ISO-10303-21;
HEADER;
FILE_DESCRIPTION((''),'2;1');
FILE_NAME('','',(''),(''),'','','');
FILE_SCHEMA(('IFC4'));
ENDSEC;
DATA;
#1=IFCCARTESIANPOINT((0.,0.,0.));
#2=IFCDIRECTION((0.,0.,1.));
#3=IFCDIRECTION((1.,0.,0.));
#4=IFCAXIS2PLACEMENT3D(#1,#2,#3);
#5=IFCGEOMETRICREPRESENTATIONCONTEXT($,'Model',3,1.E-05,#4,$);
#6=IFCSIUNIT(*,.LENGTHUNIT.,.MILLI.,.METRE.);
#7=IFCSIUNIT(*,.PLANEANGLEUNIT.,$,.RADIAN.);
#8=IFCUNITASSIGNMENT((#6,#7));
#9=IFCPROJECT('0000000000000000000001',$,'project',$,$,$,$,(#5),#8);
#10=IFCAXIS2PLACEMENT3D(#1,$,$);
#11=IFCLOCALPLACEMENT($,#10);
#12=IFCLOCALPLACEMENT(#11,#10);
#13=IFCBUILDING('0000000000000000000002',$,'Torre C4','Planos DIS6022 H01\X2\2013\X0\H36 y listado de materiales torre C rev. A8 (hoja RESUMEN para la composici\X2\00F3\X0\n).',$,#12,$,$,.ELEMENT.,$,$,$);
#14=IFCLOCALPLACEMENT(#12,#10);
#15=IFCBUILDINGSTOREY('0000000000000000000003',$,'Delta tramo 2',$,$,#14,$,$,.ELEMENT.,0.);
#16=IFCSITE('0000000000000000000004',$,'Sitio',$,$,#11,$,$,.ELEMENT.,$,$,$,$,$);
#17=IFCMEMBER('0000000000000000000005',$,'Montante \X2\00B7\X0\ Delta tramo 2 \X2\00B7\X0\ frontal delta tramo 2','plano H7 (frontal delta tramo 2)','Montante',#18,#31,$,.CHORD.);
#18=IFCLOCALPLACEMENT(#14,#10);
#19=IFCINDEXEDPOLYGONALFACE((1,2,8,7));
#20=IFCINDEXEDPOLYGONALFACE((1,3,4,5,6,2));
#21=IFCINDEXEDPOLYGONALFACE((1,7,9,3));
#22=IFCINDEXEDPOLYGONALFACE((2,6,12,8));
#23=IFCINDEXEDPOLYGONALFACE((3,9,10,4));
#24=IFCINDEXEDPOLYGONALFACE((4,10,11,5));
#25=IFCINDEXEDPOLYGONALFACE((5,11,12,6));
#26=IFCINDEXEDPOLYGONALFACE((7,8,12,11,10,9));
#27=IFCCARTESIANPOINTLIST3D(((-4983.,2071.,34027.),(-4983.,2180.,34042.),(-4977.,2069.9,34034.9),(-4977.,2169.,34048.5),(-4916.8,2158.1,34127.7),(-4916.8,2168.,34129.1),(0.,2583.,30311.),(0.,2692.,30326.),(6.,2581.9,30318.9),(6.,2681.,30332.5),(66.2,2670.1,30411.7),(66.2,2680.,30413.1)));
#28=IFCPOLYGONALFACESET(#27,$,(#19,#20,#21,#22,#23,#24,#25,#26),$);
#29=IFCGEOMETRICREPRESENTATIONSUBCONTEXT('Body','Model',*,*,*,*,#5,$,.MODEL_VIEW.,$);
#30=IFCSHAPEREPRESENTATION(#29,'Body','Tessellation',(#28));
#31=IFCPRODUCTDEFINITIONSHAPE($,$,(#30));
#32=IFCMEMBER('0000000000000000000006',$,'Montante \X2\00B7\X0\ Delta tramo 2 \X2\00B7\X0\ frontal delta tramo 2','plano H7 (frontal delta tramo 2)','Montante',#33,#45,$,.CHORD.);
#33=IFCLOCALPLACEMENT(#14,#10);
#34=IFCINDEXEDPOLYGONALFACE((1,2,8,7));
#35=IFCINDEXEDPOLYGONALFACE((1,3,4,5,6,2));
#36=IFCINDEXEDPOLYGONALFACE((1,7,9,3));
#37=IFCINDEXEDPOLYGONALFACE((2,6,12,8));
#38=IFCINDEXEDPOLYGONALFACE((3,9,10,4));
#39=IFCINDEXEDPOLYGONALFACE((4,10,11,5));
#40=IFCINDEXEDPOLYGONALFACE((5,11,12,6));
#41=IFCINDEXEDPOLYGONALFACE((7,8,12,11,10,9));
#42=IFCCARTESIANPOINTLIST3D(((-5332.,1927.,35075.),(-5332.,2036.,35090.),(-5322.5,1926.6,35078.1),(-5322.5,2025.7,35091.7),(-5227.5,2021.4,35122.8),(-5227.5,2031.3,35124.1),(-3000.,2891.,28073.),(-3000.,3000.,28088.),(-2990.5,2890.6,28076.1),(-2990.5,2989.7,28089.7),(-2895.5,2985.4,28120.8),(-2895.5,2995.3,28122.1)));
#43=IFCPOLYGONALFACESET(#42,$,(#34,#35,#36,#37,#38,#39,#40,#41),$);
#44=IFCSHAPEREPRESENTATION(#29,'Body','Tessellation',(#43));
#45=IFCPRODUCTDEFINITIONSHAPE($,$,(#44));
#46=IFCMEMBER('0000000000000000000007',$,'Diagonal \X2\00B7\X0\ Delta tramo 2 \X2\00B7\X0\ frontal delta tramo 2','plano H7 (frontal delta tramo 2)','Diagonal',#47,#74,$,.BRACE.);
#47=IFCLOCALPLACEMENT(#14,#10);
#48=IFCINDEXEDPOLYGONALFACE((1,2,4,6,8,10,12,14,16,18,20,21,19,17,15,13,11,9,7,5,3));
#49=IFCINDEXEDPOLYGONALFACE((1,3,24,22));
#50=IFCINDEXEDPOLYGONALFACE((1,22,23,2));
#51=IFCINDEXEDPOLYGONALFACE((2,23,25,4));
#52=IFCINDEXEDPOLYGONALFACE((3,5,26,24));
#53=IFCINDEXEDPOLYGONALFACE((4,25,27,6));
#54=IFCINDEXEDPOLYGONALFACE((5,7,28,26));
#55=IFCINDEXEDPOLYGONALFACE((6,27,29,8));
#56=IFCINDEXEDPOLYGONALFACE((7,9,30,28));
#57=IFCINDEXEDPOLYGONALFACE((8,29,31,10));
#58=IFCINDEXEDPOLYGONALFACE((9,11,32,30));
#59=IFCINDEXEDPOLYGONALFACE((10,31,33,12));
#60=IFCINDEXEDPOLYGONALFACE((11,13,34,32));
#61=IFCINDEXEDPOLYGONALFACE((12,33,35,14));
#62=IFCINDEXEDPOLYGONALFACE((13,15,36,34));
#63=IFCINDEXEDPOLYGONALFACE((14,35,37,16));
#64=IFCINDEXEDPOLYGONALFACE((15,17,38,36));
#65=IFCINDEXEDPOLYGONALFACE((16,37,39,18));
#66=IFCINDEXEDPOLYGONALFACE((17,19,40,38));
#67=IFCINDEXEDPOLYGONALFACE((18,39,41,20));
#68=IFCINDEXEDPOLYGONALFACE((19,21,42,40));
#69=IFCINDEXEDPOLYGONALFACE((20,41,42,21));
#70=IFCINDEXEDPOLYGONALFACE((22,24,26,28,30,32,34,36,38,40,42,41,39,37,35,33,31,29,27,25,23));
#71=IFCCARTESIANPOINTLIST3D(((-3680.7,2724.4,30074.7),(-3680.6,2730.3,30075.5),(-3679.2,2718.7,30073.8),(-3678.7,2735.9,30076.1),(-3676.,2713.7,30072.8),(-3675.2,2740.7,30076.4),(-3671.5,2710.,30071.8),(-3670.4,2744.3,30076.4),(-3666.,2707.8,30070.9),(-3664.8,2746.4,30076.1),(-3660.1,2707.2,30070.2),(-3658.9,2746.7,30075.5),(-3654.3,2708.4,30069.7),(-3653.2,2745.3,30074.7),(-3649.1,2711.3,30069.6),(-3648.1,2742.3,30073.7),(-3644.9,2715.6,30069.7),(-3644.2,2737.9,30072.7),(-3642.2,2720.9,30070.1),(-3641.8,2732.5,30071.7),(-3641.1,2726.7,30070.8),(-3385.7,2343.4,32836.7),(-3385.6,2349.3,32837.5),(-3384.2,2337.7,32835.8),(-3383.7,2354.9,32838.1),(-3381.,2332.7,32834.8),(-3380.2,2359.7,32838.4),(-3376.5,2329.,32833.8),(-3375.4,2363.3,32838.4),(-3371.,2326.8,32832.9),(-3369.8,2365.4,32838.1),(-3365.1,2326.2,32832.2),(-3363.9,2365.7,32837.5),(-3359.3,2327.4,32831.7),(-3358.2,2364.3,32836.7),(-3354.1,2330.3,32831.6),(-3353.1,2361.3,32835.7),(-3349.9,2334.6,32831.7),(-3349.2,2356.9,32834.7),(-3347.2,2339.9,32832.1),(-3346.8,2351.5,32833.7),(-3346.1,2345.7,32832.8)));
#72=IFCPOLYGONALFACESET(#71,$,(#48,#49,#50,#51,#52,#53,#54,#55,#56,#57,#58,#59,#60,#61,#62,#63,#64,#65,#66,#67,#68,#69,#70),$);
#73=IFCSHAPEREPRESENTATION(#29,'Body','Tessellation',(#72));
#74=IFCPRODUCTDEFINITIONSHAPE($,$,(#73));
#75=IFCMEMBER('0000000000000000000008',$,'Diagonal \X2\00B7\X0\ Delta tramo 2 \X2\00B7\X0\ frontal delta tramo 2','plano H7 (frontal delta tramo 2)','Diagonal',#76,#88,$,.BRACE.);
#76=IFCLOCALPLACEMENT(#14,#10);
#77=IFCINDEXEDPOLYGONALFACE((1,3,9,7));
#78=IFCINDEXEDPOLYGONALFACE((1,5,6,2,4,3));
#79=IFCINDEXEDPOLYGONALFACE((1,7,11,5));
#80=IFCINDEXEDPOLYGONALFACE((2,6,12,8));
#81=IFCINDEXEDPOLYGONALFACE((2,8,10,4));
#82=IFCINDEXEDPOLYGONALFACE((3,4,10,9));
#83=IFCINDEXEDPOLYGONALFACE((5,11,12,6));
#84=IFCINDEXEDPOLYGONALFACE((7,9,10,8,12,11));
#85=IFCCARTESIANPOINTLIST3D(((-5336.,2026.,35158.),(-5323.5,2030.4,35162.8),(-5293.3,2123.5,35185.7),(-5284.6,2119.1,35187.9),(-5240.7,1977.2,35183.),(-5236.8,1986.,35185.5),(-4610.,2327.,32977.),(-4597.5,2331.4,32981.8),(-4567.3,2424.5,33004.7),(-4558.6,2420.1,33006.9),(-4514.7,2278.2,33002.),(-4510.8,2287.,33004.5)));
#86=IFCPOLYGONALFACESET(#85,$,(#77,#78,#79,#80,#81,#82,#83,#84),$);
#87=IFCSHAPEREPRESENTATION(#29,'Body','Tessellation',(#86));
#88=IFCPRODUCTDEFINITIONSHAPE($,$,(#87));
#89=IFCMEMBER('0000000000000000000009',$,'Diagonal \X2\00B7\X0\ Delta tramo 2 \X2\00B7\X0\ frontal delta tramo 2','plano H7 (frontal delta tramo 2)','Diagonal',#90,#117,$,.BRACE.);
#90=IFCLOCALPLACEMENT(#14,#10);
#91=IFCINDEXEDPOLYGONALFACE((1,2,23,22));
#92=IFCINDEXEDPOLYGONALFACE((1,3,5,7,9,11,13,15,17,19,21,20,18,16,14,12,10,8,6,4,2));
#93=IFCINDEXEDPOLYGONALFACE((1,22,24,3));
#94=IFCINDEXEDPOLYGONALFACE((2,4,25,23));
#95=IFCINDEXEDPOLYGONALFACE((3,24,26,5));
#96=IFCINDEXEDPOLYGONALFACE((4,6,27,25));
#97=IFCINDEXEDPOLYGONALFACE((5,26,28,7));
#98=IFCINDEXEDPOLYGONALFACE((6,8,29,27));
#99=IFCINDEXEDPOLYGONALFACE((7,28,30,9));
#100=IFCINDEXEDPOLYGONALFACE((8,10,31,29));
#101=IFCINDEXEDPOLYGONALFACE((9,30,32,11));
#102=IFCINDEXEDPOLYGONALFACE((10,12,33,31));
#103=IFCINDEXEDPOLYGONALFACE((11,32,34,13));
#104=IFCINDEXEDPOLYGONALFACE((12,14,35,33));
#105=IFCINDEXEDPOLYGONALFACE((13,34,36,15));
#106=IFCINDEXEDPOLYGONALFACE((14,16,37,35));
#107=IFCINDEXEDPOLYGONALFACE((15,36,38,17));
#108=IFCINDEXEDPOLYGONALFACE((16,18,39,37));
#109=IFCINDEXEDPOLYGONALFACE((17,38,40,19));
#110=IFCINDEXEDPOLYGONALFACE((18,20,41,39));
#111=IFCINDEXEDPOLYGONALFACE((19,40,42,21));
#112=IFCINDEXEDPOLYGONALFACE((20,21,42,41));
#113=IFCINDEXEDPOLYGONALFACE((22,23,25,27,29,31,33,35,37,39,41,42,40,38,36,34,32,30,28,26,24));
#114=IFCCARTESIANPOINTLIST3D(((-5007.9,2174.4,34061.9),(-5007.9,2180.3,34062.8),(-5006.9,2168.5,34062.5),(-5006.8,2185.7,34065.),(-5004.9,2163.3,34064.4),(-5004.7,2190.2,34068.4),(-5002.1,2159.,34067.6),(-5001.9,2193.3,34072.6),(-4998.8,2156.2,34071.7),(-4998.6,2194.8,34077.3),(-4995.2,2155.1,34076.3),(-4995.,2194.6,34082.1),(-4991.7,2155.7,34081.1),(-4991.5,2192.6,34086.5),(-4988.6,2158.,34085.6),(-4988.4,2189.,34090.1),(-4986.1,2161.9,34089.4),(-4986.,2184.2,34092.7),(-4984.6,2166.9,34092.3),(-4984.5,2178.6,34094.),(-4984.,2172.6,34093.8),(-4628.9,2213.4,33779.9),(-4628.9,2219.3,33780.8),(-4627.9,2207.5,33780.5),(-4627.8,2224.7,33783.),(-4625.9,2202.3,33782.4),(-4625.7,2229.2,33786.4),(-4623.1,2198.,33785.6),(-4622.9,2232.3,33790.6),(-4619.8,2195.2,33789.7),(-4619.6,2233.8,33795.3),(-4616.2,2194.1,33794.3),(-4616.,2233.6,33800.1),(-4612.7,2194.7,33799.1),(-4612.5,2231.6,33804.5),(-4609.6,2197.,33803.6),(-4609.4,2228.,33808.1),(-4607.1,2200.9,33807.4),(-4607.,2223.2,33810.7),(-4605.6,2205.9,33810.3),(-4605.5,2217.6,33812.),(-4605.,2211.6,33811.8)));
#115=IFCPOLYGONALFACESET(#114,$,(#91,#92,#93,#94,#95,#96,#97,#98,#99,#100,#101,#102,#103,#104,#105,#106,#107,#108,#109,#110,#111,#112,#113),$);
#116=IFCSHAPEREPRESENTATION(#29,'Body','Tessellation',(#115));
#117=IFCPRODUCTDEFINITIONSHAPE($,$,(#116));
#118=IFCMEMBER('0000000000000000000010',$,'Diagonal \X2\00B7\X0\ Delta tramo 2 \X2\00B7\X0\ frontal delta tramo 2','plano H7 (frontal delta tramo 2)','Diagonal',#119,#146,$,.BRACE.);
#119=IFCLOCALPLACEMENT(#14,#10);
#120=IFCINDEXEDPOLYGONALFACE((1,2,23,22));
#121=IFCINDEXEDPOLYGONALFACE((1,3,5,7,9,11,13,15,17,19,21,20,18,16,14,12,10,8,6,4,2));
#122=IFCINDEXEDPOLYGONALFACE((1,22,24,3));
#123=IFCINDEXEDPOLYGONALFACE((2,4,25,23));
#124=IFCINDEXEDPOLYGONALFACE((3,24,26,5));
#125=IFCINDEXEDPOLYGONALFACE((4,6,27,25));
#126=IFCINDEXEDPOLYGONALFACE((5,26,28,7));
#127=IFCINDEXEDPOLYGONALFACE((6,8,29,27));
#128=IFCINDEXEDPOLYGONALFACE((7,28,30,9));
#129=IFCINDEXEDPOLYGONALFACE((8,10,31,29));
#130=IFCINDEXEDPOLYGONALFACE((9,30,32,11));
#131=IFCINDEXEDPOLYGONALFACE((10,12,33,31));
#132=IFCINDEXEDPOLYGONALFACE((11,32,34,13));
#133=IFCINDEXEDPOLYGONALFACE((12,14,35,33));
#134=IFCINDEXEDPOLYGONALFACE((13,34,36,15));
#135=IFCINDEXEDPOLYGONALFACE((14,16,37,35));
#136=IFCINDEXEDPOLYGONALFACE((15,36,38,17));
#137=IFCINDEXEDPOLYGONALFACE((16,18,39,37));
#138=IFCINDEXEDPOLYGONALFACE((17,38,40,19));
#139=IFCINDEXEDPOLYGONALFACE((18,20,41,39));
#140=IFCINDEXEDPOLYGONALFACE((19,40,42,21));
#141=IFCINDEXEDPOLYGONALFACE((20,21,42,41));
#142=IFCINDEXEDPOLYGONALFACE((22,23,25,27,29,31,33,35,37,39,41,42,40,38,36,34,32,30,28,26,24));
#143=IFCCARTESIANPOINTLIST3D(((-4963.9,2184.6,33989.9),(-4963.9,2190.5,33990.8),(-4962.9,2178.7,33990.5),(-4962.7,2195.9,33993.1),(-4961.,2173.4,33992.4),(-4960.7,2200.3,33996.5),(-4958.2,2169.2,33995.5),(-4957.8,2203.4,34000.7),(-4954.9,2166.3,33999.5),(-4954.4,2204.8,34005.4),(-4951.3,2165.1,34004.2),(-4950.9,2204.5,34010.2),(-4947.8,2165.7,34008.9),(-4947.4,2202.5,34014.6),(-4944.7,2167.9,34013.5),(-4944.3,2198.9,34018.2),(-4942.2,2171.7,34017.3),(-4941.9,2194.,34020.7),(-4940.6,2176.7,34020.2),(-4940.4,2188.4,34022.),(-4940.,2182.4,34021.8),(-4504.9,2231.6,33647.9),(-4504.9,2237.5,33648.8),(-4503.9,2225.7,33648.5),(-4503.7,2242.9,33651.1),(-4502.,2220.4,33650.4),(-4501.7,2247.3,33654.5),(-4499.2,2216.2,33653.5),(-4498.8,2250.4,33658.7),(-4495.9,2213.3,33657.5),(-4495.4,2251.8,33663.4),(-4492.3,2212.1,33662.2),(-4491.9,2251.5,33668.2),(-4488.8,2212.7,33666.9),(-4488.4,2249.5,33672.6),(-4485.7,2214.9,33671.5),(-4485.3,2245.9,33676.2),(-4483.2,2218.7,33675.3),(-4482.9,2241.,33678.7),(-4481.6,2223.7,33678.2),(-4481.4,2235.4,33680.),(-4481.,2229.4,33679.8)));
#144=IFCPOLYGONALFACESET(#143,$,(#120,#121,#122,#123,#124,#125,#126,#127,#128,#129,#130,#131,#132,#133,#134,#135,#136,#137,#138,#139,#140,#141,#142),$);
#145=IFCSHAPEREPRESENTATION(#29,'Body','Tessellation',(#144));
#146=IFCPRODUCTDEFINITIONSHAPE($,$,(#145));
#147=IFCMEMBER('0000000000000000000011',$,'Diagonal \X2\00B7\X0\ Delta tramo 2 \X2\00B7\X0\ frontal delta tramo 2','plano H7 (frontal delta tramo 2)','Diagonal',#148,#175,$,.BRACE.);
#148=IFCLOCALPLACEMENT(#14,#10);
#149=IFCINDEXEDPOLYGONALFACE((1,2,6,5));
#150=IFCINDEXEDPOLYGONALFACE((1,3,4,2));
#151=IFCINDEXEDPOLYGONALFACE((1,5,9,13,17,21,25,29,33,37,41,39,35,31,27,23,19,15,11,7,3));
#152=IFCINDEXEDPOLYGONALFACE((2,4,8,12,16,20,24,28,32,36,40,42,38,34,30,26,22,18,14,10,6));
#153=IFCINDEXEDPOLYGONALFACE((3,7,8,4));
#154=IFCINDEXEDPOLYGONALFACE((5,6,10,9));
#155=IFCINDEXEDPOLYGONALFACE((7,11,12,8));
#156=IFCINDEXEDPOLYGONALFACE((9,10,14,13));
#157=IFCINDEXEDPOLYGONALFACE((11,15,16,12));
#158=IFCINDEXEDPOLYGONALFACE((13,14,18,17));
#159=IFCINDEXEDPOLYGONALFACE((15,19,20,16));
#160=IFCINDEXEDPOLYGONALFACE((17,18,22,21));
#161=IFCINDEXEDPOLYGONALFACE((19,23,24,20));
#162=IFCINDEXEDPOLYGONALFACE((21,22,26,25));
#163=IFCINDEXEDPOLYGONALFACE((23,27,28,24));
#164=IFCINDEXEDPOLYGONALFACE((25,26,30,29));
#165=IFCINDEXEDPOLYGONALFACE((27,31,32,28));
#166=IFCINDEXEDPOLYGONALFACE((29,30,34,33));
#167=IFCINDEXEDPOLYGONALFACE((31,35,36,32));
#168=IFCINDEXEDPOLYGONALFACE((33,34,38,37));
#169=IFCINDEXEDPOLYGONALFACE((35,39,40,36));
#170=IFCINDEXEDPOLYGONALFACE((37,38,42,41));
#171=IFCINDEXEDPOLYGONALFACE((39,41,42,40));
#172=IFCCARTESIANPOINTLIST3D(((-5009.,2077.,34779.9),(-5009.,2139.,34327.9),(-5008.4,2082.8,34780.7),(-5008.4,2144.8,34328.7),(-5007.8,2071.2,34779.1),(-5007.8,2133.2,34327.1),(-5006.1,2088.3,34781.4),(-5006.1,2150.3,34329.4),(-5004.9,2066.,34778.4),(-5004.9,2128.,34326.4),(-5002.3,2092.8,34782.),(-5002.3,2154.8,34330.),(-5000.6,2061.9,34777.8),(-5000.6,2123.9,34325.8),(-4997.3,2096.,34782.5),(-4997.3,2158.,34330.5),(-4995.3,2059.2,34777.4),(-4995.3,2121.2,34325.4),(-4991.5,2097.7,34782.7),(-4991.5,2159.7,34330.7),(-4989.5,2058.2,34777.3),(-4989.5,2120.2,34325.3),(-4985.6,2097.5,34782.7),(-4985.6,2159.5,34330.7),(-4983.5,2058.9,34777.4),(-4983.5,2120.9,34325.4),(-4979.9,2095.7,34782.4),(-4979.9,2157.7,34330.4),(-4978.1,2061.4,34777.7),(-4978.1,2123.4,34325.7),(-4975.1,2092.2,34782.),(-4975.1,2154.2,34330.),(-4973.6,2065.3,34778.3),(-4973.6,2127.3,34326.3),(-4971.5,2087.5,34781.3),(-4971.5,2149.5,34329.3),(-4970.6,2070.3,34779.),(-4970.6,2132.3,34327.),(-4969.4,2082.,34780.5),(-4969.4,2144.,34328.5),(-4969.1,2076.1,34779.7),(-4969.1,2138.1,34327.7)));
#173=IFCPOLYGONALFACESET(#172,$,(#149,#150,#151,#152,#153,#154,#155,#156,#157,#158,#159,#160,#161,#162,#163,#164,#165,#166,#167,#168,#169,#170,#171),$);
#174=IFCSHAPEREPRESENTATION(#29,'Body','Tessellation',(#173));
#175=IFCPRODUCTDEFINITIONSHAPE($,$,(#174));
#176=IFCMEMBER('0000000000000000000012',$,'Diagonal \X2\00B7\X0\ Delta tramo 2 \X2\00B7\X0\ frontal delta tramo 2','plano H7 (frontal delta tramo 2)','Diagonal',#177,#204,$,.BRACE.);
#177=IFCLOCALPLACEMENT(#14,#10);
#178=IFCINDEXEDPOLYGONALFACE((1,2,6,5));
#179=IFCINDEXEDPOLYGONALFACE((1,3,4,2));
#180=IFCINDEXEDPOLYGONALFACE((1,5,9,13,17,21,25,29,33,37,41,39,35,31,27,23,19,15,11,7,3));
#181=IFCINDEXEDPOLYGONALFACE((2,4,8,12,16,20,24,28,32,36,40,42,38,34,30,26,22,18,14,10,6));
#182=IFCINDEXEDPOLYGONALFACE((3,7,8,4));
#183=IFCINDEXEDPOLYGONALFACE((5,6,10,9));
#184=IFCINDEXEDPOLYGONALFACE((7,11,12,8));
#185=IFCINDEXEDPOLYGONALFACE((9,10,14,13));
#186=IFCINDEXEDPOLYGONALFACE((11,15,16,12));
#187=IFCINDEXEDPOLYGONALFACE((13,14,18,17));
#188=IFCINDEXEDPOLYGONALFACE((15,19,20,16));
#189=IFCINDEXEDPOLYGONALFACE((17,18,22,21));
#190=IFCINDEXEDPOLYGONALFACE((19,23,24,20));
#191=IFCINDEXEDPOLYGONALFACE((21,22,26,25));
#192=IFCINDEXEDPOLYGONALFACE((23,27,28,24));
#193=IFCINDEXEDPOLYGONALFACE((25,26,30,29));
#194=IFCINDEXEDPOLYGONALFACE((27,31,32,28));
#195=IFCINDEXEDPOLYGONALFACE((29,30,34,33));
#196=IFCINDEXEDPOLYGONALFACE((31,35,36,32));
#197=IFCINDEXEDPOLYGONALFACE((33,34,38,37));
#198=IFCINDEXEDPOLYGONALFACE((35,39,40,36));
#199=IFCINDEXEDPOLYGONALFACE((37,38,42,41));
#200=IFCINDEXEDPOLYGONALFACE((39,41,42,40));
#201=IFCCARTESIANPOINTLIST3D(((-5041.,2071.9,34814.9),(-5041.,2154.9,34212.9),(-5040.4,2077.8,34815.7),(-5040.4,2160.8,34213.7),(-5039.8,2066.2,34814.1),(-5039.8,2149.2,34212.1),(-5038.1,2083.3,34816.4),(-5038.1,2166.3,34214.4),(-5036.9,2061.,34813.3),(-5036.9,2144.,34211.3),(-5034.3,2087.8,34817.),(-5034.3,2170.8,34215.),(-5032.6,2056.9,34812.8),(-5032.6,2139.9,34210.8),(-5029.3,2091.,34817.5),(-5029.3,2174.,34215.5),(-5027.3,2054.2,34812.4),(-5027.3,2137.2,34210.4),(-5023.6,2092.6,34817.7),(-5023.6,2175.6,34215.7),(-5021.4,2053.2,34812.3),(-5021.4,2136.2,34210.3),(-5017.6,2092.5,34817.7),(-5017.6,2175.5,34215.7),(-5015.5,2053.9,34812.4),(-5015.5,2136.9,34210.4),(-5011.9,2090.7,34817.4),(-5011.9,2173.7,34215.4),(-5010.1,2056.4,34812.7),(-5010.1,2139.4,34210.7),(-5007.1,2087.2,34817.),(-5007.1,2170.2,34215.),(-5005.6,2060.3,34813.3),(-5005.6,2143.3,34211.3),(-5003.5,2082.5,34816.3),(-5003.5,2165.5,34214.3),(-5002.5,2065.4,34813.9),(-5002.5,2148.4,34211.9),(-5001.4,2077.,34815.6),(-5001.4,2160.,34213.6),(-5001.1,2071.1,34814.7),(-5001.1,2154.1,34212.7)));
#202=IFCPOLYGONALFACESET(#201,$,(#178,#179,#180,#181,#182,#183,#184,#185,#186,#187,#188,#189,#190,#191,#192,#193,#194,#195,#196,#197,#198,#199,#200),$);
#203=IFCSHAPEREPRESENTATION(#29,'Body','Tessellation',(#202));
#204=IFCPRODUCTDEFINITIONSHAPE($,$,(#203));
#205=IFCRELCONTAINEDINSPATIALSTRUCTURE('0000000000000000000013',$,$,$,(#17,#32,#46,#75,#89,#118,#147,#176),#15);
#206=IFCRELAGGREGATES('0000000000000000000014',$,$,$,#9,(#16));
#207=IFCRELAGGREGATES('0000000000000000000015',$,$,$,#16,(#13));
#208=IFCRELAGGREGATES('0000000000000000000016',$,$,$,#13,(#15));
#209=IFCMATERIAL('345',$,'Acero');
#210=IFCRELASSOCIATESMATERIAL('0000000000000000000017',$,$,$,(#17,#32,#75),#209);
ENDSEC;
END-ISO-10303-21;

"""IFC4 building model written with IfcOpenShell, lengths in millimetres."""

from ifc_helpers import new_model, si_unit, frame, frame_2d, origin, origin_with_axes, place, context, subcontext, project, spatial, circle, l_section, extrude, material, element, save


model = new_model("IFC4")

# Units and contexts
model_context = context("Model", 3, precision=1e-05, world=origin_with_axes())
body_context = subcontext(model_context, "Body", "Model", "MODEL_VIEW")
ifc_project = project(units=[si_unit("LENGTHUNIT", "METRE", prefix="MILLI"), si_unit("PLANEANGLEUNIT", "RADIAN")], contexts=[model_context])

# Site, building, storey
site_placement = place(None, origin())
site = spatial("IfcSite", under=ifc_project, at=site_placement, Name="Sitio", CompositionType="ELEMENT")
building_placement = place(site_placement, origin())
building = spatial("IfcBuilding", under=site, at=building_placement, Name="Torre C4", Description="Planos DIS6022 H01–H36 y listado de materiales torre C rev. A8 (hoja RESUMEN para la composición).", CompositionType="ELEMENT")
storey_placement = place(building_placement, origin())
storey = spatial("IfcBuildingStorey", under=building, at=storey_placement, Name="Delta tramo 2", CompositionType="ELEMENT", Elevation=0.0)

# Members
ifc_material_1 = material(Name="345", Category="Acero")
member_1_placement = place(storey_placement, frame((-4983.0, 2180.0, 34042.0), z_axis=(0.798932, 0.08209, -0.595792), x_axis=(0.601421, -0.109049, 0.791455)))
element("IfcMember", 1, at=member_1_placement, inside=storey, material=ifc_material_1, Name="Montante · Delta tramo 2 · frontal delta tramo 2", Description="plano H7 (frontal delta tramo 2)", ObjectType="Montante", PredefinedType="CHORD", context=body_context, shape_type="SweptSolid", body=[
    extrude(l_section(Depth=110.0, Width=110.0, Thickness=10.0, at=frame_2d((55.0, 55.0))), None, (0.0, 0.0, 1.0), 6237.1),
])
member_2_placement = place(storey_placement, frame((-5332.0, 2036.0, 35090.0), z_axis=(0.313322, 0.129521, -0.940773), x_axis=(0.949647, -0.042734, 0.310394)))
element("IfcMember", 2, at=member_2_placement, inside=storey, material=ifc_material_1, Name="Montante · Delta tramo 2 · frontal delta tramo 2", Description="plano H7 (frontal delta tramo 2)", ObjectType="Montante", PredefinedType="CHORD", context=body_context, shape_type="SweptSolid", body=[
    extrude(l_section(Depth=110.0, Width=110.0, Thickness=10.0, at=frame_2d((55.0, 55.0))), None, (0.0, 0.0, 1.0), 7442.8),
])
member_3_placement = place(storey_placement, frame((-3366.0, 2346.0, 32835.0), z_axis=(-0.105217, 0.135891, -0.985121), x_axis=(0.804453, -0.570742, -0.164651)))
element("IfcMember", 3, at=member_3_placement, inside=storey, Name="Diagonal · Delta tramo 2 · frontal delta tramo 2", Description="plano H7 (frontal delta tramo 2)", ObjectType="Diagonal", PredefinedType="BRACE", context=body_context, shape_type="SweptSolid", body=[
    extrude(circle(Radius=20.0), None, (0.0, 0.0, 1.0), 2803.7),
])
member_4_placement = place(storey_placement, frame((-4610.0, 2327.0, 32977.0), z_axis=(-0.313163, -0.129837, 0.940782), x_axis=(0.866801, -0.443846, 0.227281)))
element("IfcMember", 4, at=member_4_placement, inside=storey, material=ifc_material_1, Name="Diagonal · Delta tramo 2 · frontal delta tramo 2", Description="plano H7 (frontal delta tramo 2)", ObjectType="Diagonal", PredefinedType="BRACE", context=body_context, shape_type="SweptSolid", body=[
    extrude(l_section(Depth=110.0, Width=110.0, Thickness=10.0, at=frame_2d((55.0, 55.0))), None, (0.0, 0.0, 1.0), 2318.3),
])
member_5_placement = place(storey_placement, frame((-4996.0, 2175.0, 34078.0), z_axis=(0.79956, 0.082277, -0.594923), x_axis=(0.493139, -0.655346, 0.572132)))
element("IfcMember", 5, at=member_5_placement, inside=storey, Name="Diagonal · Delta tramo 2 · frontal delta tramo 2", Description="plano H7 (frontal delta tramo 2)", ObjectType="Diagonal", PredefinedType="BRACE", context=body_context, shape_type="SweptSolid", body=[
    extrude(circle(Radius=20.0), None, (0.0, 0.0, 1.0), 474.0),
])
member_6_placement = place(storey_placement, frame((-4952.0, 2185.0, 34006.0), z_axis=(0.799193, 0.081835, -0.595477), x_axis=(0.48996, -0.662562, 0.566524)))
element("IfcMember", 6, at=member_6_placement, inside=storey, Name="Diagonal · Delta tramo 2 · frontal delta tramo 2", Description="plano H7 (frontal delta tramo 2)", ObjectType="Diagonal", PredefinedType="BRACE", context=body_context, shape_type="SweptSolid", body=[
    extrude(circle(Radius=20.0), None, (0.0, 0.0, 1.0), 574.3),
])
member_7_placement = place(storey_placement, frame((-4989.0, 2140.0, 34328.0), z_axis=(0.0, -0.135896, 0.990723), x_axis=(0.922374, -0.382714, -0.052496)))
element("IfcMember", 7, at=member_7_placement, inside=storey, Name="Diagonal · Delta tramo 2 · frontal delta tramo 2", Description="plano H7 (frontal delta tramo 2)", ObjectType="Diagonal", PredefinedType="BRACE", context=body_context, shape_type="SweptSolid", body=[
    extrude(circle(Radius=20.0), None, (0.0, 0.0, 1.0), 456.2),
])
member_8_placement = place(storey_placement, frame((-5021.0, 2156.0, 34213.0), z_axis=(0.0, -0.136582, 0.990629), x_axis=(0.922907, -0.381415, -0.052587)))
element("IfcMember", 8, at=member_8_placement, inside=storey, Name="Diagonal · Delta tramo 2 · frontal delta tramo 2", Description="plano H7 (frontal delta tramo 2)", ObjectType="Diagonal", PredefinedType="BRACE", context=body_context, shape_type="SweptSolid", body=[
    extrude(circle(Radius=20.0), None, (0.0, 0.0, 1.0), 607.7),
])

save(model, "model.ifc")
